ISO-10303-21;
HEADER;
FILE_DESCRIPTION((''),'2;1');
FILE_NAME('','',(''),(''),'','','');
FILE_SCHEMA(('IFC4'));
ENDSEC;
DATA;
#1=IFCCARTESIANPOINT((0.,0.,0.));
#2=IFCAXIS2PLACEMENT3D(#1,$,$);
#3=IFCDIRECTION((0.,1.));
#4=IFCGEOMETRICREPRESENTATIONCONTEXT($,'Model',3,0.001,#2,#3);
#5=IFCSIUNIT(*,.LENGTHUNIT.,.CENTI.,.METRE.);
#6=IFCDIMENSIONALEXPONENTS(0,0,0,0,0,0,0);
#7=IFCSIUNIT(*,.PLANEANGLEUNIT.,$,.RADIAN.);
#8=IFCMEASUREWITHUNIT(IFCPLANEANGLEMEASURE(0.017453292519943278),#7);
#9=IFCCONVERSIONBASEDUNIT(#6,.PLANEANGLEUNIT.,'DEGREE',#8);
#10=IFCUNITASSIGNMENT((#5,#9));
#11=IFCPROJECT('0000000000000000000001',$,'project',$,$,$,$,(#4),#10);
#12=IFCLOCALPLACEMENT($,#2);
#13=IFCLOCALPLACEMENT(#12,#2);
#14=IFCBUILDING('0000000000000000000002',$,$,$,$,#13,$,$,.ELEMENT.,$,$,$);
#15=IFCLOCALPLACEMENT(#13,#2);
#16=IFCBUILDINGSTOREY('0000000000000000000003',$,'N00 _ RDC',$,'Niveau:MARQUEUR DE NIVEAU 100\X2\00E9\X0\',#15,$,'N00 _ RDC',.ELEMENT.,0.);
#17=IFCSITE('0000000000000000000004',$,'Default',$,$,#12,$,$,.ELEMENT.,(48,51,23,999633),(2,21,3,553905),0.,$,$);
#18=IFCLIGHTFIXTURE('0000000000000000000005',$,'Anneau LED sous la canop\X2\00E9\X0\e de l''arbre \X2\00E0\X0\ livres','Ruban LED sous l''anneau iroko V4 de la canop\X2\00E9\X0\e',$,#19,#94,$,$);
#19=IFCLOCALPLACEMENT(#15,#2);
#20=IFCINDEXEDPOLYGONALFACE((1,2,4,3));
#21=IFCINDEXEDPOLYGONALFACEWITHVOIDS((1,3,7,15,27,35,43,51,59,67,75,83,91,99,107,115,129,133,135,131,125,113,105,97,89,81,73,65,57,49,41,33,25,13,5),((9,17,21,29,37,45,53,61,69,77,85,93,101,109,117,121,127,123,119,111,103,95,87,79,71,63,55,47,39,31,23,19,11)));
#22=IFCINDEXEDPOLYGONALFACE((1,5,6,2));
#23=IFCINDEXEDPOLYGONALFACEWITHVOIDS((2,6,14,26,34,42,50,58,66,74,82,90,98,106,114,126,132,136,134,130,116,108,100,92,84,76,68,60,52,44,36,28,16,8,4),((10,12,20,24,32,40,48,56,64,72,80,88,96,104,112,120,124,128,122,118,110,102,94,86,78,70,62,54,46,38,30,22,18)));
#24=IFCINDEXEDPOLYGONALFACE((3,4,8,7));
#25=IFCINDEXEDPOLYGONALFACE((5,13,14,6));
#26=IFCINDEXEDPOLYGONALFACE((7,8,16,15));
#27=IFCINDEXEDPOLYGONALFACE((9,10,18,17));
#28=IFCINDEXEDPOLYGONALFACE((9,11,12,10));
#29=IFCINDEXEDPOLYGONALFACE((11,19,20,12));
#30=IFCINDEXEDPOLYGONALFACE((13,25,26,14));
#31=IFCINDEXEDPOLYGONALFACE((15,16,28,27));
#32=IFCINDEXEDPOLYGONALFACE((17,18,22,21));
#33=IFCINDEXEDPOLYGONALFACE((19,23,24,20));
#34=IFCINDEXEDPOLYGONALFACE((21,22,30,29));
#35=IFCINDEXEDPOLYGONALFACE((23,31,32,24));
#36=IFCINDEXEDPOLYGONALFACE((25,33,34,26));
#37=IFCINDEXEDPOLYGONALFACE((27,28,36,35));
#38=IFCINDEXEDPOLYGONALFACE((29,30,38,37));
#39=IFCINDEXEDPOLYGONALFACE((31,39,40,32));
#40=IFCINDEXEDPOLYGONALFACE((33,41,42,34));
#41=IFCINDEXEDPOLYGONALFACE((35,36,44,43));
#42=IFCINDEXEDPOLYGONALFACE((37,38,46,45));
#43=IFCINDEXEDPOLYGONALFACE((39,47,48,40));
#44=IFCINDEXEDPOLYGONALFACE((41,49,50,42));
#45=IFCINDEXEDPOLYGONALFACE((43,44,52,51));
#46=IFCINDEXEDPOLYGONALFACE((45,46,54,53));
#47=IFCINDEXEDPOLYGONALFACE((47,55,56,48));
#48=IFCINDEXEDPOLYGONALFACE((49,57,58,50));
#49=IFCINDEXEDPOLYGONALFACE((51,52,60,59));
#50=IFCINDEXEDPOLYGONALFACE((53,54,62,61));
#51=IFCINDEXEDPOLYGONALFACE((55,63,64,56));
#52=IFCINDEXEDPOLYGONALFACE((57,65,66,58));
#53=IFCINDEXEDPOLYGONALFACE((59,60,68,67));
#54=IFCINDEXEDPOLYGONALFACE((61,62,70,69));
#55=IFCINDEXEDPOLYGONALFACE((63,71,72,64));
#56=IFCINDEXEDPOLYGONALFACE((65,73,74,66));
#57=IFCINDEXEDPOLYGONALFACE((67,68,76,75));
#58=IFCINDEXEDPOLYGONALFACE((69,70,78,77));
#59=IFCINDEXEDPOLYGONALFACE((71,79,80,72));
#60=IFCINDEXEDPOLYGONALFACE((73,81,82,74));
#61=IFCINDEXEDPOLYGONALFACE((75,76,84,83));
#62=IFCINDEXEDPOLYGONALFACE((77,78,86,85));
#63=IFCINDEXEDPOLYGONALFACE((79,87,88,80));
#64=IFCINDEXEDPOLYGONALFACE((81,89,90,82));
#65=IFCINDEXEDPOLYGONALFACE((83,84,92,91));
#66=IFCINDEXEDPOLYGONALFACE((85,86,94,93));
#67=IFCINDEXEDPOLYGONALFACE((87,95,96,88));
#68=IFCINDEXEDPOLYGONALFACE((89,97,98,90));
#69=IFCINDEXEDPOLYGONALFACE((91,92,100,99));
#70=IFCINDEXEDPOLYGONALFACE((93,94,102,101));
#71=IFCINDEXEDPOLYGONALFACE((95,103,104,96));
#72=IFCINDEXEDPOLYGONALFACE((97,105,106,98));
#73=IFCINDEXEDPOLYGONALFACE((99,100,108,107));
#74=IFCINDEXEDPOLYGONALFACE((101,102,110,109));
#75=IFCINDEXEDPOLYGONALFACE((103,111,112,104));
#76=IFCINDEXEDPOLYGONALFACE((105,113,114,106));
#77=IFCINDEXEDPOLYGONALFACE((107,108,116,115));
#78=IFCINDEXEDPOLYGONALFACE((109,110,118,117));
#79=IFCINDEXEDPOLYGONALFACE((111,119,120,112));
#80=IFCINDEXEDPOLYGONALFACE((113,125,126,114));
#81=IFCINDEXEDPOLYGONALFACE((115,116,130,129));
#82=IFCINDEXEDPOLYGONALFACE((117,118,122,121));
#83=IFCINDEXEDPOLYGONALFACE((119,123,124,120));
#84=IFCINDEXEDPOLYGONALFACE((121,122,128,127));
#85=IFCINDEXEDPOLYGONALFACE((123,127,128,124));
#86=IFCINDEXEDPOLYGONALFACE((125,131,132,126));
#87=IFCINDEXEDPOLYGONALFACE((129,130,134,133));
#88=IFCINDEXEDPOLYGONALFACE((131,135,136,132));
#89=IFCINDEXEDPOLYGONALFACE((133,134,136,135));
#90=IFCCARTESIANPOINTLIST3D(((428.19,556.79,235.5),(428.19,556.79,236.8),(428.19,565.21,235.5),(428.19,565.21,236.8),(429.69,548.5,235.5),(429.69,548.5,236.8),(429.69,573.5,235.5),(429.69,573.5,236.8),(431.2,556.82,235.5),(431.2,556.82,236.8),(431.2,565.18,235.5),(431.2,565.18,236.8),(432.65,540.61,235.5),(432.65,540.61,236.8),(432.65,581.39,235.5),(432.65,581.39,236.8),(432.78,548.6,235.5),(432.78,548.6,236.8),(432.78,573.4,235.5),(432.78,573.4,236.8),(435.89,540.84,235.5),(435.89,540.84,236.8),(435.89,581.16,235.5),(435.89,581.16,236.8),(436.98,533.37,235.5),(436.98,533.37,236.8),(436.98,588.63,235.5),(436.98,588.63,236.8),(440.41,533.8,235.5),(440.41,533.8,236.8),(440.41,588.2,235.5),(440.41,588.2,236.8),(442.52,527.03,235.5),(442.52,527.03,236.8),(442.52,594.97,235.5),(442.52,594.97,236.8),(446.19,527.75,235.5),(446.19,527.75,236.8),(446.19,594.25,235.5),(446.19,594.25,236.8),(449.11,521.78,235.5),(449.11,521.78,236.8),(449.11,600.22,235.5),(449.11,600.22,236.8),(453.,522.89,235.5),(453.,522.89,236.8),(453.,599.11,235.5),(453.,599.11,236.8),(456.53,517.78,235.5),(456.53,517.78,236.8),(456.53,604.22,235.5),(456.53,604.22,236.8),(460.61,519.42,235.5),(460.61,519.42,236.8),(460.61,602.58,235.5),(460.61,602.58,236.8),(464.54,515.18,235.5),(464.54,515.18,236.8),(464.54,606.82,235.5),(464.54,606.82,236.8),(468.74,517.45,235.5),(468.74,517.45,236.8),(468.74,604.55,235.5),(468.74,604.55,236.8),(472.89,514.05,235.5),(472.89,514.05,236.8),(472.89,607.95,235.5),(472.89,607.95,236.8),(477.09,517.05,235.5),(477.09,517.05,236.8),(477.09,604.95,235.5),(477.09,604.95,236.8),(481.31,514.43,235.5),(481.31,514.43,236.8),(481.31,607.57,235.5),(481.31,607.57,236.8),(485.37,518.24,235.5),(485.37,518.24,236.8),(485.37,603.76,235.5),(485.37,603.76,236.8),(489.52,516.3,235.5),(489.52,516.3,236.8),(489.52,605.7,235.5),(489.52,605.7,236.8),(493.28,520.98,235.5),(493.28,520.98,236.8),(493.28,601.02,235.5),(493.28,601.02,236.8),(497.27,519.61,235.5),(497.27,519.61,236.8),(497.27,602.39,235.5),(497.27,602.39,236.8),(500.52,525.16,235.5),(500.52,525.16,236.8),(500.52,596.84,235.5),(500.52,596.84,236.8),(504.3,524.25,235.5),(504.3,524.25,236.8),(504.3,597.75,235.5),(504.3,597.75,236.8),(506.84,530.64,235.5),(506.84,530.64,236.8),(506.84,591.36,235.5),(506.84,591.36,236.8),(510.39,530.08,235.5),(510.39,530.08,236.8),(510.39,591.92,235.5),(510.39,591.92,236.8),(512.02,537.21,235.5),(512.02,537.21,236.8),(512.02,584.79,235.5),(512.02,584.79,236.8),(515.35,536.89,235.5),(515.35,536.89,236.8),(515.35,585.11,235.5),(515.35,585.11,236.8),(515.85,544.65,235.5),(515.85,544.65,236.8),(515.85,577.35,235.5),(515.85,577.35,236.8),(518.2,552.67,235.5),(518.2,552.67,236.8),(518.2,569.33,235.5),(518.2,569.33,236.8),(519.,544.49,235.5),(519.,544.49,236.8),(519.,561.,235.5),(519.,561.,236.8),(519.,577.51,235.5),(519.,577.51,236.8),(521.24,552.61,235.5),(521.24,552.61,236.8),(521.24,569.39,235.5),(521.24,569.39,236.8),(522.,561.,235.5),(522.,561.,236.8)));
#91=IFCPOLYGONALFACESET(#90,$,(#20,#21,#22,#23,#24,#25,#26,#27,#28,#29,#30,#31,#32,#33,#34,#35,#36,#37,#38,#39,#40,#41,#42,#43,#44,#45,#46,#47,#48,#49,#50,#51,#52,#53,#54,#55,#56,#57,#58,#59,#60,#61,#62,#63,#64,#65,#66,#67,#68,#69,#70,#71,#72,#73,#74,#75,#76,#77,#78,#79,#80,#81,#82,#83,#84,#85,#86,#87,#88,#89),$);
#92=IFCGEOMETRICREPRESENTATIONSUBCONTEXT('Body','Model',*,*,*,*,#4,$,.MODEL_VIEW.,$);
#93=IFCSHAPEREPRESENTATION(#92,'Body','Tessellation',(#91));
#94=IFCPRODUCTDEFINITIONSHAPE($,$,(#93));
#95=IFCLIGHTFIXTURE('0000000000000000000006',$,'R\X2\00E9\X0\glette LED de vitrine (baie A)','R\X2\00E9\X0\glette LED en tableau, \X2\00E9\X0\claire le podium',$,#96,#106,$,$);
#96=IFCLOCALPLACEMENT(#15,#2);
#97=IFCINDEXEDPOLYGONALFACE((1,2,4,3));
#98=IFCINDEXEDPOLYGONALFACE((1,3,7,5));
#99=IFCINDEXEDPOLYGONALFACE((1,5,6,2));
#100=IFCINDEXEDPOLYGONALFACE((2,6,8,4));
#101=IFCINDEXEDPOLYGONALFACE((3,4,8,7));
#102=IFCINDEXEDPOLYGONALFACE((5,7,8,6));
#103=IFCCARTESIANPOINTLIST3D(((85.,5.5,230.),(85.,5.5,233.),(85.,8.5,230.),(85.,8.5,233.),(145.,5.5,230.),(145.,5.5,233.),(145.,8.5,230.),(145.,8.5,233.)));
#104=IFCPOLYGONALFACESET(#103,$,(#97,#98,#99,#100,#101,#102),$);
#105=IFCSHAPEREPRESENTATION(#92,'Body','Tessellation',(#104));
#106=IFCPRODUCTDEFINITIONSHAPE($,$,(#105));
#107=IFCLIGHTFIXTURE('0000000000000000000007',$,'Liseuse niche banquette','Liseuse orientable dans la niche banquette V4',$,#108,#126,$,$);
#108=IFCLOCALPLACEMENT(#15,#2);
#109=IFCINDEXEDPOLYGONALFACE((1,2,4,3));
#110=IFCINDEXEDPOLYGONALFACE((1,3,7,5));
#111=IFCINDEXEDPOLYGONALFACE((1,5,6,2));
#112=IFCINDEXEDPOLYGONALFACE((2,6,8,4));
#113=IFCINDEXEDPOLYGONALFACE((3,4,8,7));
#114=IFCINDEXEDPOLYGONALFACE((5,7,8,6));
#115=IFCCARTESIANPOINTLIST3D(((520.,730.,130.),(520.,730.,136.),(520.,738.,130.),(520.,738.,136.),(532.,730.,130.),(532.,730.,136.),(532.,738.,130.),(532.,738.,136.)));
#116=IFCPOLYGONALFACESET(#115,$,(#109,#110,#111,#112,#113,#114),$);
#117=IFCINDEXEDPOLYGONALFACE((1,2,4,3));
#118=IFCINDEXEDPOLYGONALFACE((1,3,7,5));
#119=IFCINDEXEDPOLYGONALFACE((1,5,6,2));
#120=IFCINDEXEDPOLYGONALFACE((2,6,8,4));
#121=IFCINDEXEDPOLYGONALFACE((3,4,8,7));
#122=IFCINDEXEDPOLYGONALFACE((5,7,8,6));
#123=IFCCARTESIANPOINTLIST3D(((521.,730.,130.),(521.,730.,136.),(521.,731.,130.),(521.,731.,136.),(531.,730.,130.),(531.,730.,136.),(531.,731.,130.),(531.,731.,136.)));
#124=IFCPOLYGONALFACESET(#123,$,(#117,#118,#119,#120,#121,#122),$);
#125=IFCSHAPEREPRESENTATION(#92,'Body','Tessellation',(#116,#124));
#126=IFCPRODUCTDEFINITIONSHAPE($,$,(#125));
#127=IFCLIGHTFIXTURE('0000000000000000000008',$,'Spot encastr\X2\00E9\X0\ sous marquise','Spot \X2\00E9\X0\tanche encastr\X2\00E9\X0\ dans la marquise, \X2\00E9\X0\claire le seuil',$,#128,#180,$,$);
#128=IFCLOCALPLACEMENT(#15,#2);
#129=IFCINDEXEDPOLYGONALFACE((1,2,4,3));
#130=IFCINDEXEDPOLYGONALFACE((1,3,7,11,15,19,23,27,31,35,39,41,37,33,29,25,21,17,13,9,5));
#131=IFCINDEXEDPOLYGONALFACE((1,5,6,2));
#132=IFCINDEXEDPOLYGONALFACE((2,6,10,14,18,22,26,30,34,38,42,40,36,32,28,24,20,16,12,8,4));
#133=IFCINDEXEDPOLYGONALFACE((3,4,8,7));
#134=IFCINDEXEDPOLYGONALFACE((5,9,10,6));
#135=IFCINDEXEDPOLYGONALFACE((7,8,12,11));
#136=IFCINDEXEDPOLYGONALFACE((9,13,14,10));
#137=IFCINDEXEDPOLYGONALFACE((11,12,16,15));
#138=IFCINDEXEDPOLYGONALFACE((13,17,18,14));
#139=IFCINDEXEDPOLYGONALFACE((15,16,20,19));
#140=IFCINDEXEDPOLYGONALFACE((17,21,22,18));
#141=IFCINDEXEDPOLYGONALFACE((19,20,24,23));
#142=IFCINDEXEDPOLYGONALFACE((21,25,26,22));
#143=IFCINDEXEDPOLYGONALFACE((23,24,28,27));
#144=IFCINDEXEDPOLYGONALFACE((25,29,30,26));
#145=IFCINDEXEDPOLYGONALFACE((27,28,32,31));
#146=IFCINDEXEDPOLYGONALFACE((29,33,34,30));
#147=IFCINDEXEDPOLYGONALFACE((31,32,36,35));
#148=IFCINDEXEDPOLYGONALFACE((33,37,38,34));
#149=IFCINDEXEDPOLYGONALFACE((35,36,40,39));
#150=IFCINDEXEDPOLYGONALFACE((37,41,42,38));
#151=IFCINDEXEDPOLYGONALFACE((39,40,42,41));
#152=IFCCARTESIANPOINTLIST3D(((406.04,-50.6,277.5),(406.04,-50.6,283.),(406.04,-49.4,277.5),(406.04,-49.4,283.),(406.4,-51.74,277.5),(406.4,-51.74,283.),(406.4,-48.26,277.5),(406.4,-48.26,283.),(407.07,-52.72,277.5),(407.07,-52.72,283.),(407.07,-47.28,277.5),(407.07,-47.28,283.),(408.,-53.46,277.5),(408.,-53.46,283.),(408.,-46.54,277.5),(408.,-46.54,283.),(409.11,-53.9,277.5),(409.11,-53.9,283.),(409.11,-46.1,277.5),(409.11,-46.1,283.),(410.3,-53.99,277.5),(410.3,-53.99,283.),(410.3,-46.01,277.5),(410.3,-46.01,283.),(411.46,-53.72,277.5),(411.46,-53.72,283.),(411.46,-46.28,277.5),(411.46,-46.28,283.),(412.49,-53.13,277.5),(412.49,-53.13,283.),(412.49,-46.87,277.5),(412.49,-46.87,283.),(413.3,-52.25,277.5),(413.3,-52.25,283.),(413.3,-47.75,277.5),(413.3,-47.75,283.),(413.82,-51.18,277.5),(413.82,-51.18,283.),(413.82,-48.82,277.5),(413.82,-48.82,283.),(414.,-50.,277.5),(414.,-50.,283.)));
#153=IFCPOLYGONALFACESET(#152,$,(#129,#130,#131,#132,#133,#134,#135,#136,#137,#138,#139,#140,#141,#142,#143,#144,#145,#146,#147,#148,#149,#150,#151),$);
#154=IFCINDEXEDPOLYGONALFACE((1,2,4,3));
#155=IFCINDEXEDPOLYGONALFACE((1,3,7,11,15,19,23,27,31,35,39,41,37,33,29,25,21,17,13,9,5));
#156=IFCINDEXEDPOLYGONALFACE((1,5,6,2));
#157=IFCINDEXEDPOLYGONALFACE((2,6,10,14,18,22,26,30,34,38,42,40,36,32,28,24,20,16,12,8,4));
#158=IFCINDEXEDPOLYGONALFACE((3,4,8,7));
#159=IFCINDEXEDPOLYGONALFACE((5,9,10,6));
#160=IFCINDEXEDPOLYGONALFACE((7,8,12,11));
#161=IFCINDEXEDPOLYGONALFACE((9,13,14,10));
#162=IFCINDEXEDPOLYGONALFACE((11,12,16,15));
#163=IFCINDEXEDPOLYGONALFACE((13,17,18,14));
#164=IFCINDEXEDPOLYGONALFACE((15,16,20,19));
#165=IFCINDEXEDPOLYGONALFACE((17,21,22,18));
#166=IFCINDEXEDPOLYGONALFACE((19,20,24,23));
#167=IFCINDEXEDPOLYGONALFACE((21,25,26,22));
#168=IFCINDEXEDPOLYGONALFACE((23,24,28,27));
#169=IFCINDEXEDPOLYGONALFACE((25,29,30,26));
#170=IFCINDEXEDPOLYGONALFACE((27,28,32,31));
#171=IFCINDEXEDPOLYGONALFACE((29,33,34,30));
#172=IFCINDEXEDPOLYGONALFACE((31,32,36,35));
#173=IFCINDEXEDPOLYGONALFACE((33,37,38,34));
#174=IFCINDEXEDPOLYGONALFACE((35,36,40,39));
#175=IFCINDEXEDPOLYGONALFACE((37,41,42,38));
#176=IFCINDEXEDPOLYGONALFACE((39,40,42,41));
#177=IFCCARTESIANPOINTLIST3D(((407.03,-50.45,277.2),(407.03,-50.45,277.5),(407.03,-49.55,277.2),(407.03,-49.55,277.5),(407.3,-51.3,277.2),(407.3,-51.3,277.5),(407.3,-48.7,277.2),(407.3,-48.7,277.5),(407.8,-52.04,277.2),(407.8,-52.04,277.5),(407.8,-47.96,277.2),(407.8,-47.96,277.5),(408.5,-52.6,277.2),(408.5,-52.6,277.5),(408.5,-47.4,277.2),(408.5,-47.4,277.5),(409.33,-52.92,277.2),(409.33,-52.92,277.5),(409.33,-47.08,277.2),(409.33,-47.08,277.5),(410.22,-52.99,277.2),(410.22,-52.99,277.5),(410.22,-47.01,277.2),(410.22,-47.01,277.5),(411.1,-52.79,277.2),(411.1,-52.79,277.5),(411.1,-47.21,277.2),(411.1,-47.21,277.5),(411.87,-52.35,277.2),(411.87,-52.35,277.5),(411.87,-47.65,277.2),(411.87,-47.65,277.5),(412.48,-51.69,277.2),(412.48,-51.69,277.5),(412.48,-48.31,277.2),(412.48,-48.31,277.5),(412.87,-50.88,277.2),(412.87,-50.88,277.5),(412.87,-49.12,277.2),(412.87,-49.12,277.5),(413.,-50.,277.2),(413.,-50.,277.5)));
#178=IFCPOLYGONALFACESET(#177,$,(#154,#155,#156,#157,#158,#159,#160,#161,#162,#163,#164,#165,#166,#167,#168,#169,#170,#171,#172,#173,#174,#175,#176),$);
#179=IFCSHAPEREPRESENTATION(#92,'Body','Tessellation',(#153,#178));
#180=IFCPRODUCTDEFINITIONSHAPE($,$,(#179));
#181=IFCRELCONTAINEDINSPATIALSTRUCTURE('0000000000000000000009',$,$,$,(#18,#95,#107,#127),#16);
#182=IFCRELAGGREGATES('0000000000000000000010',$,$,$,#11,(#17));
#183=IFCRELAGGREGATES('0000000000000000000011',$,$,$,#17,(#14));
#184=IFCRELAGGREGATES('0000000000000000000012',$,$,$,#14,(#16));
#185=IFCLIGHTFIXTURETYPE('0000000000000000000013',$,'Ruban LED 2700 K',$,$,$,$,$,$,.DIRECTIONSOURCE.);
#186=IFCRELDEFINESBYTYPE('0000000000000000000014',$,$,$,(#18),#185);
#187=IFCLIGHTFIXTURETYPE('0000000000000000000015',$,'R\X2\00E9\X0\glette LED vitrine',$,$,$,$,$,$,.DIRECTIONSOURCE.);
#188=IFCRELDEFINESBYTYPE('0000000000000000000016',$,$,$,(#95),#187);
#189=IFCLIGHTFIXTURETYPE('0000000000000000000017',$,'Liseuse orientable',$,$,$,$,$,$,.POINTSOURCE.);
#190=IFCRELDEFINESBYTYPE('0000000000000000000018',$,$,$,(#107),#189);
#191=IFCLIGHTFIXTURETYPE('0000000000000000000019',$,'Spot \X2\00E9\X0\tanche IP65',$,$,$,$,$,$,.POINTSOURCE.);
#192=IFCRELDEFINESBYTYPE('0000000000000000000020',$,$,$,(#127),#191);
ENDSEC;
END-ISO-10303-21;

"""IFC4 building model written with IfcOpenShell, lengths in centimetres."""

from ifc_helpers import new_model, entity, si_unit, converted_unit, direction, frame, frame_2d, origin, origin_with_axes, place, context, subcontext, project, spatial, rectangle, circle, hollow_circle, extrude, type_object, element, save


model = new_model("IFC4")

# Units and contexts
model_context = context("Model", 3, precision=0.001, world=origin(), true_north=direction((0.0, 1.0)))
body_context = subcontext(model_context, "Body", "Model", "MODEL_VIEW")
ifc_project = project(units=[si_unit("LENGTHUNIT", "METRE", prefix="CENTI"), converted_unit("PLANEANGLEUNIT", "DEGREE", entity("IfcPlaneAngleMeasure", 0.017453292519943278), si_unit("PLANEANGLEUNIT", "RADIAN"), dimensions=[0, 0, 0, 0, 0, 0, 0])], contexts=[model_context])

# Site, building, storey
site_placement = place(None, origin())
site = spatial("IfcSite", under=ifc_project, at=site_placement, Name="Default", CompositionType="ELEMENT", RefLatitude=(48, 51, 23, 999633), RefLongitude=(2, 21, 3, 553905), RefElevation=0.0)
building_placement = place(site_placement, origin())
building = spatial("IfcBuilding", under=site, at=building_placement, CompositionType="ELEMENT")
storey_placement = place(building_placement, origin())
storey = spatial("IfcBuildingStorey", under=building, at=storey_placement, Name="N00 _ RDC", ObjectType="Niveau:MARQUEUR DE NIVEAU 100é", LongName="N00 _ RDC", CompositionType="ELEMENT", Elevation=0.0)

# Light fixtures
light_fixture_type_1 = type_object("IfcLightFixtureType", Name="Ruban LED 2700 K", PredefinedType="DIRECTIONSOURCE")
light_fixture_1_placement = place(storey_placement, origin_with_axes())
element("IfcLightFixture", 1, at=light_fixture_1_placement, inside=storey, type_object=light_fixture_type_1, Name="Anneau LED sous la canopée de l'arbre à livres", Description="Ruban LED sous l'anneau iroko V4 de la canopée", context=body_context, shape_type="SweptSolid", body=[
    extrude(hollow_circle(Radius=47.0, WallThickness=3.0, at=frame_2d((475.0, 561.0))), frame((0.0, 0.0, 235.5)), (0.0, 0.0, 1.0), 1.3),
])
light_fixture_type_2 = type_object("IfcLightFixtureType", Name="Réglette LED vitrine", PredefinedType="DIRECTIONSOURCE")
light_fixture_2_placement = place(storey_placement, origin_with_axes())
element("IfcLightFixture", 2, at=light_fixture_2_placement, inside=storey, type_object=light_fixture_type_2, Name="Réglette LED de vitrine (baie A)", Description="Réglette LED en tableau, éclaire le podium", context=body_context, shape_type="SweptSolid", body=[
    extrude(rectangle(XDim=60.0, YDim=3.0, at=frame_2d((115.0, 7.0))), frame((0.0, 0.0, 230.0)), (0.0, 0.0, 1.0), 3.0),
])
light_fixture_type_3 = type_object("IfcLightFixtureType", Name="Liseuse orientable", PredefinedType="POINTSOURCE")
light_fixture_3_placement = place(storey_placement, origin_with_axes())
element("IfcLightFixture", 3, at=light_fixture_3_placement, inside=storey, type_object=light_fixture_type_3, Name="Liseuse niche banquette", Description="Liseuse orientable dans la niche banquette V4", context=body_context, shape_type="SweptSolid", body=[
    extrude(rectangle(XDim=12.0, YDim=8.0, at=frame_2d((526.0, 734.0))), frame((0.0, 0.0, 130.0)), (0.0, 0.0, 1.0), 6.0),
    extrude(rectangle(XDim=10.0, YDim=1.0, at=frame_2d((526.0, 730.5))), frame((0.0, 0.0, 130.0)), (0.0, 0.0, 1.0), 6.0),
])
light_fixture_type_4 = type_object("IfcLightFixtureType", Name="Spot étanche IP65", PredefinedType="POINTSOURCE")
light_fixture_4_placement = place(storey_placement, origin_with_axes())
element("IfcLightFixture", 4, at=light_fixture_4_placement, inside=storey, type_object=light_fixture_type_4, Name="Spot encastré sous marquise", Description="Spot étanche encastré dans la marquise, éclaire le seuil", context=body_context, shape_type="SweptSolid", body=[
    extrude(circle(Radius=4.0, at=frame_2d((410.0, -50.0))), frame((0.0, 0.0, 277.5)), (0.0, 0.0, 1.0), 5.5),
    extrude(circle(Radius=3.0, at=frame_2d((410.0, -50.0))), frame((0.0, 0.0, 277.2)), (0.0, 0.0, 1.0), 0.3),
])

save(model, "model.ifc")
